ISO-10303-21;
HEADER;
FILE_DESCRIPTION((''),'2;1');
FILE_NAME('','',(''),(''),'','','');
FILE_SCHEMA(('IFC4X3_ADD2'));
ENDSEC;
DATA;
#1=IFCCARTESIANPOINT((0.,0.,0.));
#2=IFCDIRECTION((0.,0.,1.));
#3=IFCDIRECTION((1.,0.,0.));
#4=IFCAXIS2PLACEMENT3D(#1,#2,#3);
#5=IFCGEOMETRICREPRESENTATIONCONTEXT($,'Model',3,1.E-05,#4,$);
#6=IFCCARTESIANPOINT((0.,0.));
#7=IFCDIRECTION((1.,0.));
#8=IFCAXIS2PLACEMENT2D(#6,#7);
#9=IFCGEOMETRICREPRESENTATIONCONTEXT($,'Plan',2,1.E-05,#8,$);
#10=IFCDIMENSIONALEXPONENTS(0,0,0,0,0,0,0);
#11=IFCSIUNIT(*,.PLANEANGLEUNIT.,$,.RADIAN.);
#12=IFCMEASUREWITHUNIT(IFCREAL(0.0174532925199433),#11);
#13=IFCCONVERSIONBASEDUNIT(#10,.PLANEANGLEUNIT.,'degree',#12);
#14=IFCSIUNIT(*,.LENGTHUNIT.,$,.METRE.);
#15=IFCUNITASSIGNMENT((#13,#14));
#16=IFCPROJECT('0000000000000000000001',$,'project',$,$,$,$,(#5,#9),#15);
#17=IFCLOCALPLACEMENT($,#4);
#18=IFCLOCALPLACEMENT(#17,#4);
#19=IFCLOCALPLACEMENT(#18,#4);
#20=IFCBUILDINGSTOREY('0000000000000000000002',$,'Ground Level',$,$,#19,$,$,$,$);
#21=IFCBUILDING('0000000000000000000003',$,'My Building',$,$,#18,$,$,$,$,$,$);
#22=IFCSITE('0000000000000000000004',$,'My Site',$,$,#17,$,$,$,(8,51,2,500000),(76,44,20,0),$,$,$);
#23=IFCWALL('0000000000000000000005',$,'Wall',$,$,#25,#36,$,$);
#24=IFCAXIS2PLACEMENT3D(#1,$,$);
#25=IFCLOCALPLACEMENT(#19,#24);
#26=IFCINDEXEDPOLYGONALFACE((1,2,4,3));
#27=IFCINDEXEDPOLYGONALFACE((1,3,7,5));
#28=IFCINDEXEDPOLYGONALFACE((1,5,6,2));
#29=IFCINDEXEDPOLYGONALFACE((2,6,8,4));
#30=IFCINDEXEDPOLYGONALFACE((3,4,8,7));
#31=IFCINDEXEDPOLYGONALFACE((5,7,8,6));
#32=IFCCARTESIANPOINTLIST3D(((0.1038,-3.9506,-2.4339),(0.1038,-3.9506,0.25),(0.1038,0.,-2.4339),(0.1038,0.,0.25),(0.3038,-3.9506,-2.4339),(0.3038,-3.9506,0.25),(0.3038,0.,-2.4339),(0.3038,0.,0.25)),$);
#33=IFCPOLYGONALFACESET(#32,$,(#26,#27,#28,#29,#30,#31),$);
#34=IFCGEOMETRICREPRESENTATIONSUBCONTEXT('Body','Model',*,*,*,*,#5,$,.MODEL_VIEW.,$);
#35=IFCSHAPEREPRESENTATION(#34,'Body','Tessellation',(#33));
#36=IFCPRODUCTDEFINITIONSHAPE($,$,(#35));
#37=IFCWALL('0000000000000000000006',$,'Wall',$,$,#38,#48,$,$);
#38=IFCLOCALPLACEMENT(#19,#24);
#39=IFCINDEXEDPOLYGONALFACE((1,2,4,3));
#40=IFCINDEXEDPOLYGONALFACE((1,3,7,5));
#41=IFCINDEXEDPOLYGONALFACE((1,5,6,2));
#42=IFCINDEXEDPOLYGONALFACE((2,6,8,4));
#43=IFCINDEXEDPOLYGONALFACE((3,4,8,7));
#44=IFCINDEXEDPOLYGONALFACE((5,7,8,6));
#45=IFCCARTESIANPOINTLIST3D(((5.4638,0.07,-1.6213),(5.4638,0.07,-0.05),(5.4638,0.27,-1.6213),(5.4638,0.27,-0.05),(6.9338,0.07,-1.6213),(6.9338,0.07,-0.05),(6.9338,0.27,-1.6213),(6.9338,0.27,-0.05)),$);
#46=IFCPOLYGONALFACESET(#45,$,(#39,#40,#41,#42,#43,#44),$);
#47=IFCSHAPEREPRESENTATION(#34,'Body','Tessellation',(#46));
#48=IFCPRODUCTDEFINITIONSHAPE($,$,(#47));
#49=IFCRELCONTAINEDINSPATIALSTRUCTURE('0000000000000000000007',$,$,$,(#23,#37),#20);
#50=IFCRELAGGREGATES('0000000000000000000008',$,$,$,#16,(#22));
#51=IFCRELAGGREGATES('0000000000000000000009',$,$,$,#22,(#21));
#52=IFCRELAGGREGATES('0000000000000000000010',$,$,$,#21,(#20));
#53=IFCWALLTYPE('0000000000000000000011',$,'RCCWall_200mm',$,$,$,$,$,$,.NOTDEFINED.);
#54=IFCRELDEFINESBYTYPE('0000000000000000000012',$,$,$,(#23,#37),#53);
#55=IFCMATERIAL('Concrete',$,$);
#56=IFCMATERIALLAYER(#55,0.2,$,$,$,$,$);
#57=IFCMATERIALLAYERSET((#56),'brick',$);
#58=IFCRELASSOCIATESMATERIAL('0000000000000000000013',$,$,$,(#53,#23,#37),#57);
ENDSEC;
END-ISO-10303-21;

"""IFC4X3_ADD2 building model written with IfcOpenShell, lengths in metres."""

from ifc_helpers import new_model, entity, si_unit, converted_unit, frame, origin_with_axes, origin_2d_with_axis, place, context, subcontext, project, spatial, line, indexed_curve, outline, extrude, material, layer, layer_set, layer_usage, type_object, element, save


model = new_model("IFC4X3_ADD2")

# Units and contexts
model_context = context("Model", 3, precision=1e-05, world=origin_with_axes())
plan_context = context("Plan", 2, precision=1e-05, world=origin_2d_with_axis())
body_context = subcontext(model_context, "Body", "Model", "MODEL_VIEW")
ifc_project = project(units=[converted_unit("PLANEANGLEUNIT", "degree", entity("IfcReal", 0.0174532925199433), si_unit("PLANEANGLEUNIT", "RADIAN"), dimensions=[0, 0, 0, 0, 0, 0, 0]), si_unit("LENGTHUNIT", "METRE")], contexts=[model_context, plan_context])

# Site, building, storey
site_placement = place(None, origin_with_axes())
site = spatial("IfcSite", under=ifc_project, at=site_placement, Name="My Site", RefLatitude=(8, 51, 2, 500000), RefLongitude=(76, 44, 20, 0))
building_placement = place(site_placement, origin_with_axes())
building = spatial("IfcBuilding", under=site, at=building_placement, Name="My Building")
storey_placement = place(building_placement, origin_with_axes())
storey = spatial("IfcBuildingStorey", under=building, at=storey_placement, Name="Ground Level")

# Walls
ifc_material_1 = material(Name="Concrete")
ifc_layer_1 = layer(ifc_material_1, 0.2)
ifc_layer_set_1 = layer_set([ifc_layer_1], Name="brick")
wall_type_1 = type_object("IfcWallType", Name="RCCWall_200mm", PredefinedType="NOTDEFINED", material=ifc_layer_set_1)
ifc_layer_usage_1 = layer_usage(ifc_layer_set_1, "AXIS2", "POSITIVE", 0.0)
wall_1_placement = place(storey_placement, frame((0.3038, -3.9506, -2.4339), z_axis=(0.0, 0.0, 1.0), x_axis=(0.0, 1.0, 0.0)))
element("IfcWall", 1, at=wall_1_placement, inside=storey, type_object=wall_type_1, material=ifc_layer_usage_1, Name="Wall", context=body_context, shape_type="SweptSolid", body=[
    extrude(outline(indexed_curve([(0.0, 0.0), (0.0, 0.2), (3.9506, 0.2), (3.9506, 0.0)], segments=[line(1, 2, 3, 4, 1)])), origin_with_axes(), (0.0, 0.0, 1.0), 2.6839),
])
ifc_layer_usage_2 = layer_usage(ifc_layer_set_1, "AXIS2", "POSITIVE", 0.0)
wall_2_placement = place(storey_placement, frame((5.4638, 0.07, -1.6213), z_axis=(0.0, 0.0, 1.0), x_axis=(1.0, -0.000001, 0.0)))
element("IfcWall", 2, at=wall_2_placement, inside=storey, type_object=wall_type_1, material=ifc_layer_usage_2, Name="Wall", context=body_context, shape_type="SweptSolid", body=[
    extrude(outline(indexed_curve([(0.0, 0.0), (0.0, 0.2), (1.47, 0.2), (1.47, 0.0)], segments=[line(1, 2, 3, 4, 1)])), origin_with_axes(), (0.0, 0.0, 1.0), 1.5713),
])

save(model, "model.ifc")
